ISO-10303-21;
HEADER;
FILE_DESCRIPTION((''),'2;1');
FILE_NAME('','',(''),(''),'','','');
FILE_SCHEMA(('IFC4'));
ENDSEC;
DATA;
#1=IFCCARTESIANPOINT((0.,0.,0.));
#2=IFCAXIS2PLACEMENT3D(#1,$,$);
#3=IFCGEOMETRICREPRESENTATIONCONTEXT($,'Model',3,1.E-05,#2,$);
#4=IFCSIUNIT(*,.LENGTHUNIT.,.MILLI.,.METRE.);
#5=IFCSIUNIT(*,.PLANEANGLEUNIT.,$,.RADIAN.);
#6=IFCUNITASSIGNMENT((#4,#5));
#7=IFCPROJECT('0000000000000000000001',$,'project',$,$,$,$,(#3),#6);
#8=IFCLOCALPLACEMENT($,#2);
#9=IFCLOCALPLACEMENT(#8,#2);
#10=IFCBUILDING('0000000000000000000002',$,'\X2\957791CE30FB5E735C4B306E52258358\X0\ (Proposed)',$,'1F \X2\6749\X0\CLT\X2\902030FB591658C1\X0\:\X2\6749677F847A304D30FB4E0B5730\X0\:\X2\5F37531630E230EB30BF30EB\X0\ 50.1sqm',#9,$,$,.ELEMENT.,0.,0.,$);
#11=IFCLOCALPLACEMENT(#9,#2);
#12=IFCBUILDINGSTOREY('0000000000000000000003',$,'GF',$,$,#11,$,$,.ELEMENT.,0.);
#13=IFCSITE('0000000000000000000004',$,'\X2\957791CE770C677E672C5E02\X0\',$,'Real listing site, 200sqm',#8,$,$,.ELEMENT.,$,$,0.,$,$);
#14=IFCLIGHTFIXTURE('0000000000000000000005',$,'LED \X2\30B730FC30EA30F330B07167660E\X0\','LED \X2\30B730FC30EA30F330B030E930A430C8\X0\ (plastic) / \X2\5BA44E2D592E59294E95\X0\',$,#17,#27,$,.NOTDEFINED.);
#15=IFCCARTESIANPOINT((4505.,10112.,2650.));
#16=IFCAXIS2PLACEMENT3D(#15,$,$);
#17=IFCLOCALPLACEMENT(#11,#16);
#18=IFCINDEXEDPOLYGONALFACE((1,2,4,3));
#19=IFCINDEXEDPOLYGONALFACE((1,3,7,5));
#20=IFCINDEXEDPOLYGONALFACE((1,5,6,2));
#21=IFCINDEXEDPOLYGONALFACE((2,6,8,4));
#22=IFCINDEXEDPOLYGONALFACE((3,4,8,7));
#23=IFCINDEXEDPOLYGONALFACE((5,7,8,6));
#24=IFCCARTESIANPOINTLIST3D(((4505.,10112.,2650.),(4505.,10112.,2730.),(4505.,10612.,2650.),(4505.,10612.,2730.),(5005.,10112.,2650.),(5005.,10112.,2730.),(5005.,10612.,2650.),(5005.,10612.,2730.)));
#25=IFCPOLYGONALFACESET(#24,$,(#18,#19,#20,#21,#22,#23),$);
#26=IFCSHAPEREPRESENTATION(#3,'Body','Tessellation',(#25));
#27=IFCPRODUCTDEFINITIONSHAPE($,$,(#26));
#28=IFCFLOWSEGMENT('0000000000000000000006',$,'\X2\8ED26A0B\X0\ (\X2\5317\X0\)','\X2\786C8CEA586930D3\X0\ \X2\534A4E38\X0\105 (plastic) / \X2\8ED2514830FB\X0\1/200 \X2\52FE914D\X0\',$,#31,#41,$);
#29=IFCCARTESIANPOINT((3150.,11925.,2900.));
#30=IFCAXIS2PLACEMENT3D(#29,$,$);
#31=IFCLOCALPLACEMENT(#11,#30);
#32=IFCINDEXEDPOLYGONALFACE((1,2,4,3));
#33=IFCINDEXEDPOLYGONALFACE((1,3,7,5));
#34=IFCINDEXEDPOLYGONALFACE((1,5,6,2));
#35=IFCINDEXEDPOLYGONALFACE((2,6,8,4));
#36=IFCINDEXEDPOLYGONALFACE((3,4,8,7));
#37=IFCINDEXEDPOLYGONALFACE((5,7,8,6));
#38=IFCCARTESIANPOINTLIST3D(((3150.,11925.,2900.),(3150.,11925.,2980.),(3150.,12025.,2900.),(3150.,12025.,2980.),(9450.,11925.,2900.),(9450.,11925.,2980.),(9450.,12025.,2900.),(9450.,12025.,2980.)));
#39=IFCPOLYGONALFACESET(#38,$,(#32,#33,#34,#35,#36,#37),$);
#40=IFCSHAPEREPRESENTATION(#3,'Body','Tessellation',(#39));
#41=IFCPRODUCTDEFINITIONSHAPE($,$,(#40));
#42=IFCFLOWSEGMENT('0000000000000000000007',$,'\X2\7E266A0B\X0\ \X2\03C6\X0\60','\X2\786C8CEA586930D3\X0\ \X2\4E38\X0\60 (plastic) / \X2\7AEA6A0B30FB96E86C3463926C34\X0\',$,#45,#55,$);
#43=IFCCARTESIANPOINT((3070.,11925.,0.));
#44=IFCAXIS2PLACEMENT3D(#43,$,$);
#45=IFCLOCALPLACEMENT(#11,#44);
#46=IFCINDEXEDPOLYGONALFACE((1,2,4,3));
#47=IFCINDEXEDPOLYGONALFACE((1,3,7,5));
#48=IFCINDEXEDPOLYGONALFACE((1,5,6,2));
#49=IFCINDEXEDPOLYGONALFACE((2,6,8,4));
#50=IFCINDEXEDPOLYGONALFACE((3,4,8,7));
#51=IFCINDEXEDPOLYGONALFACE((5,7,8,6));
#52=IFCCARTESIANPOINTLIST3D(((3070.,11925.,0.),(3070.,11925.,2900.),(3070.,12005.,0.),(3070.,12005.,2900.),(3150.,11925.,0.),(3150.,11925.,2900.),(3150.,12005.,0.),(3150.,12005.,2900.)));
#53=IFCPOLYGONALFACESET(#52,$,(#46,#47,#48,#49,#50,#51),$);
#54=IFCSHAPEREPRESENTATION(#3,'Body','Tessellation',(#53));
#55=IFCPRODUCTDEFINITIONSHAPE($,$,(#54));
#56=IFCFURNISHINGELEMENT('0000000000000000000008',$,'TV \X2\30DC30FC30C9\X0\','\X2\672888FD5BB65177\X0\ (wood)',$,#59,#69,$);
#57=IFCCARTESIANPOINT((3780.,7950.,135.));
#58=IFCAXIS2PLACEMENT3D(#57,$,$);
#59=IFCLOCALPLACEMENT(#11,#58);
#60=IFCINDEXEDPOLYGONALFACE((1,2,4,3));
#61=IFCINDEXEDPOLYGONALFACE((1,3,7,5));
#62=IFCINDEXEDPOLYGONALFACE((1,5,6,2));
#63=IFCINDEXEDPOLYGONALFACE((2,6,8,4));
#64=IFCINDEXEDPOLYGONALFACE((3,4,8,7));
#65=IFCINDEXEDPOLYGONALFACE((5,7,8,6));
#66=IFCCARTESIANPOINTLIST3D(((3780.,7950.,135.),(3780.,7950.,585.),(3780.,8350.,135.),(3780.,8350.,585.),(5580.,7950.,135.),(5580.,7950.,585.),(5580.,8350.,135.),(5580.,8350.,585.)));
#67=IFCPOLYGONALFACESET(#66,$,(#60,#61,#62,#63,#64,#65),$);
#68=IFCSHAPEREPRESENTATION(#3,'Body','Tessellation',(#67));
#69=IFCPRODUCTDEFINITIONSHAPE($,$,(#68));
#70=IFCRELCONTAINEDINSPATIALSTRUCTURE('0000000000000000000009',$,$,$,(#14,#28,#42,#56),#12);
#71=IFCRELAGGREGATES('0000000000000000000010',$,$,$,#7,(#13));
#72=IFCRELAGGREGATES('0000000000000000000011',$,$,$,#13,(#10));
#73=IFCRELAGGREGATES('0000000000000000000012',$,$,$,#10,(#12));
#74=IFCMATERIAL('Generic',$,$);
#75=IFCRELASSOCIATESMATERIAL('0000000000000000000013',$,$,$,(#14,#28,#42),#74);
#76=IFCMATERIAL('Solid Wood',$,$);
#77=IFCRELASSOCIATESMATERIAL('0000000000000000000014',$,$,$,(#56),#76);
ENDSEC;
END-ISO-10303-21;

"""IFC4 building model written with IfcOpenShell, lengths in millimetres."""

from ifc_helpers import new_model, si_unit, frame, frame_2d, origin, place, context, project, spatial, rectangle, extrude, material, element, save


model = new_model("IFC4")

# Units and contexts
model_context = context("Model", 3, precision=1e-05, world=origin())
ifc_project = project(units=[si_unit("LENGTHUNIT", "METRE", prefix="MILLI"), si_unit("PLANEANGLEUNIT", "RADIAN")], contexts=[model_context])

# Site, building, storey
site_placement = place(None, origin())
site = spatial("IfcSite", under=ifc_project, at=site_placement, Name="長野県松本市", ObjectType="Real listing site, 200sqm", CompositionType="ELEMENT", RefElevation=0.0)
building_placement = place(site_placement, origin())
building = spatial("IfcBuilding", under=site, at=building_placement, Name="長野・平屋の別荘 (Proposed)", ObjectType="1F 杉CLT造・外壁:杉板葺き・下地:強化モルタル 50.1sqm", CompositionType="ELEMENT", ElevationOfRefHeight=0.0, ElevationOfTerrain=0.0)
storey_placement = place(building_placement, origin())
storey = spatial("IfcBuildingStorey", under=building, at=storey_placement, Name="GF", CompositionType="ELEMENT", Elevation=0.0)

# Shared definitions
ifc_material_1 = material(Name="Solid Wood")

# Shared definitions
ifc_material_2 = material(Name="Generic")

# Light fixture
light_fixture_placement = place(storey_placement, frame((4505.0, 10112.0, 2650.0)))
element("IfcLightFixture", 1, at=light_fixture_placement, inside=storey, material=ifc_material_2, Name="LED シーリング照明", Description="LED シーリングライト (plastic) / 室中央天井", PredefinedType="NOTDEFINED", context=model_context, shape_type="SweptSolid", body=[
    extrude(rectangle(XDim=500.0, YDim=500.0, at=frame_2d((250.0, 250.0))), frame((4505.0, 10112.0, 2650.0)), (0.0, 0.0, 1.0), 80.0),
])

# Flow segments
flow_segment_1_placement = place(storey_placement, frame((3150.0, 11925.0, 2900.0)))
element("IfcFlowSegment", 2, at=flow_segment_1_placement, inside=storey, material=ifc_material_2, Name="軒樋 (北)", Description="硬質塩ビ 半丸105 (plastic) / 軒先・1/200 勾配", context=model_context, shape_type="SweptSolid", body=[
    extrude(rectangle(XDim=6300.0, YDim=100.0, at=frame_2d((3150.0, 50.0))), frame((3150.0, 11925.0, 2900.0)), (0.0, 0.0, 1.0), 80.0),
])
flow_segment_2_placement = place(storey_placement, frame((3070.0, 11925.0, 0.0)))
element("IfcFlowSegment", 3, at=flow_segment_2_placement, inside=storey, material=ifc_material_2, Name="縦樋 φ60", Description="硬質塩ビ 丸60 (plastic) / 竪樋・雨水排水", context=model_context, shape_type="SweptSolid", body=[
    extrude(rectangle(XDim=80.0, YDim=80.0, at=frame_2d((40.0, 40.0))), frame((3070.0, 11925.0, 0.0)), (0.0, 0.0, 1.0), 2900.0),
])

# Furnishing element
furnishing_placement = place(storey_placement, frame((3780.0, 7950.0, 135.0)))
element("IfcFurnishingElement", 4, at=furnishing_placement, inside=storey, material=ifc_material_1, Name="TV ボード", Description="木製家具 (wood)", context=model_context, shape_type="SweptSolid", body=[
    extrude(rectangle(XDim=1800.0, YDim=400.0, at=frame_2d((900.0, 200.0))), frame((3780.0, 7950.0, 135.0)), (0.0, 0.0, 1.0), 450.0),
])

save(model, "model.ifc")
